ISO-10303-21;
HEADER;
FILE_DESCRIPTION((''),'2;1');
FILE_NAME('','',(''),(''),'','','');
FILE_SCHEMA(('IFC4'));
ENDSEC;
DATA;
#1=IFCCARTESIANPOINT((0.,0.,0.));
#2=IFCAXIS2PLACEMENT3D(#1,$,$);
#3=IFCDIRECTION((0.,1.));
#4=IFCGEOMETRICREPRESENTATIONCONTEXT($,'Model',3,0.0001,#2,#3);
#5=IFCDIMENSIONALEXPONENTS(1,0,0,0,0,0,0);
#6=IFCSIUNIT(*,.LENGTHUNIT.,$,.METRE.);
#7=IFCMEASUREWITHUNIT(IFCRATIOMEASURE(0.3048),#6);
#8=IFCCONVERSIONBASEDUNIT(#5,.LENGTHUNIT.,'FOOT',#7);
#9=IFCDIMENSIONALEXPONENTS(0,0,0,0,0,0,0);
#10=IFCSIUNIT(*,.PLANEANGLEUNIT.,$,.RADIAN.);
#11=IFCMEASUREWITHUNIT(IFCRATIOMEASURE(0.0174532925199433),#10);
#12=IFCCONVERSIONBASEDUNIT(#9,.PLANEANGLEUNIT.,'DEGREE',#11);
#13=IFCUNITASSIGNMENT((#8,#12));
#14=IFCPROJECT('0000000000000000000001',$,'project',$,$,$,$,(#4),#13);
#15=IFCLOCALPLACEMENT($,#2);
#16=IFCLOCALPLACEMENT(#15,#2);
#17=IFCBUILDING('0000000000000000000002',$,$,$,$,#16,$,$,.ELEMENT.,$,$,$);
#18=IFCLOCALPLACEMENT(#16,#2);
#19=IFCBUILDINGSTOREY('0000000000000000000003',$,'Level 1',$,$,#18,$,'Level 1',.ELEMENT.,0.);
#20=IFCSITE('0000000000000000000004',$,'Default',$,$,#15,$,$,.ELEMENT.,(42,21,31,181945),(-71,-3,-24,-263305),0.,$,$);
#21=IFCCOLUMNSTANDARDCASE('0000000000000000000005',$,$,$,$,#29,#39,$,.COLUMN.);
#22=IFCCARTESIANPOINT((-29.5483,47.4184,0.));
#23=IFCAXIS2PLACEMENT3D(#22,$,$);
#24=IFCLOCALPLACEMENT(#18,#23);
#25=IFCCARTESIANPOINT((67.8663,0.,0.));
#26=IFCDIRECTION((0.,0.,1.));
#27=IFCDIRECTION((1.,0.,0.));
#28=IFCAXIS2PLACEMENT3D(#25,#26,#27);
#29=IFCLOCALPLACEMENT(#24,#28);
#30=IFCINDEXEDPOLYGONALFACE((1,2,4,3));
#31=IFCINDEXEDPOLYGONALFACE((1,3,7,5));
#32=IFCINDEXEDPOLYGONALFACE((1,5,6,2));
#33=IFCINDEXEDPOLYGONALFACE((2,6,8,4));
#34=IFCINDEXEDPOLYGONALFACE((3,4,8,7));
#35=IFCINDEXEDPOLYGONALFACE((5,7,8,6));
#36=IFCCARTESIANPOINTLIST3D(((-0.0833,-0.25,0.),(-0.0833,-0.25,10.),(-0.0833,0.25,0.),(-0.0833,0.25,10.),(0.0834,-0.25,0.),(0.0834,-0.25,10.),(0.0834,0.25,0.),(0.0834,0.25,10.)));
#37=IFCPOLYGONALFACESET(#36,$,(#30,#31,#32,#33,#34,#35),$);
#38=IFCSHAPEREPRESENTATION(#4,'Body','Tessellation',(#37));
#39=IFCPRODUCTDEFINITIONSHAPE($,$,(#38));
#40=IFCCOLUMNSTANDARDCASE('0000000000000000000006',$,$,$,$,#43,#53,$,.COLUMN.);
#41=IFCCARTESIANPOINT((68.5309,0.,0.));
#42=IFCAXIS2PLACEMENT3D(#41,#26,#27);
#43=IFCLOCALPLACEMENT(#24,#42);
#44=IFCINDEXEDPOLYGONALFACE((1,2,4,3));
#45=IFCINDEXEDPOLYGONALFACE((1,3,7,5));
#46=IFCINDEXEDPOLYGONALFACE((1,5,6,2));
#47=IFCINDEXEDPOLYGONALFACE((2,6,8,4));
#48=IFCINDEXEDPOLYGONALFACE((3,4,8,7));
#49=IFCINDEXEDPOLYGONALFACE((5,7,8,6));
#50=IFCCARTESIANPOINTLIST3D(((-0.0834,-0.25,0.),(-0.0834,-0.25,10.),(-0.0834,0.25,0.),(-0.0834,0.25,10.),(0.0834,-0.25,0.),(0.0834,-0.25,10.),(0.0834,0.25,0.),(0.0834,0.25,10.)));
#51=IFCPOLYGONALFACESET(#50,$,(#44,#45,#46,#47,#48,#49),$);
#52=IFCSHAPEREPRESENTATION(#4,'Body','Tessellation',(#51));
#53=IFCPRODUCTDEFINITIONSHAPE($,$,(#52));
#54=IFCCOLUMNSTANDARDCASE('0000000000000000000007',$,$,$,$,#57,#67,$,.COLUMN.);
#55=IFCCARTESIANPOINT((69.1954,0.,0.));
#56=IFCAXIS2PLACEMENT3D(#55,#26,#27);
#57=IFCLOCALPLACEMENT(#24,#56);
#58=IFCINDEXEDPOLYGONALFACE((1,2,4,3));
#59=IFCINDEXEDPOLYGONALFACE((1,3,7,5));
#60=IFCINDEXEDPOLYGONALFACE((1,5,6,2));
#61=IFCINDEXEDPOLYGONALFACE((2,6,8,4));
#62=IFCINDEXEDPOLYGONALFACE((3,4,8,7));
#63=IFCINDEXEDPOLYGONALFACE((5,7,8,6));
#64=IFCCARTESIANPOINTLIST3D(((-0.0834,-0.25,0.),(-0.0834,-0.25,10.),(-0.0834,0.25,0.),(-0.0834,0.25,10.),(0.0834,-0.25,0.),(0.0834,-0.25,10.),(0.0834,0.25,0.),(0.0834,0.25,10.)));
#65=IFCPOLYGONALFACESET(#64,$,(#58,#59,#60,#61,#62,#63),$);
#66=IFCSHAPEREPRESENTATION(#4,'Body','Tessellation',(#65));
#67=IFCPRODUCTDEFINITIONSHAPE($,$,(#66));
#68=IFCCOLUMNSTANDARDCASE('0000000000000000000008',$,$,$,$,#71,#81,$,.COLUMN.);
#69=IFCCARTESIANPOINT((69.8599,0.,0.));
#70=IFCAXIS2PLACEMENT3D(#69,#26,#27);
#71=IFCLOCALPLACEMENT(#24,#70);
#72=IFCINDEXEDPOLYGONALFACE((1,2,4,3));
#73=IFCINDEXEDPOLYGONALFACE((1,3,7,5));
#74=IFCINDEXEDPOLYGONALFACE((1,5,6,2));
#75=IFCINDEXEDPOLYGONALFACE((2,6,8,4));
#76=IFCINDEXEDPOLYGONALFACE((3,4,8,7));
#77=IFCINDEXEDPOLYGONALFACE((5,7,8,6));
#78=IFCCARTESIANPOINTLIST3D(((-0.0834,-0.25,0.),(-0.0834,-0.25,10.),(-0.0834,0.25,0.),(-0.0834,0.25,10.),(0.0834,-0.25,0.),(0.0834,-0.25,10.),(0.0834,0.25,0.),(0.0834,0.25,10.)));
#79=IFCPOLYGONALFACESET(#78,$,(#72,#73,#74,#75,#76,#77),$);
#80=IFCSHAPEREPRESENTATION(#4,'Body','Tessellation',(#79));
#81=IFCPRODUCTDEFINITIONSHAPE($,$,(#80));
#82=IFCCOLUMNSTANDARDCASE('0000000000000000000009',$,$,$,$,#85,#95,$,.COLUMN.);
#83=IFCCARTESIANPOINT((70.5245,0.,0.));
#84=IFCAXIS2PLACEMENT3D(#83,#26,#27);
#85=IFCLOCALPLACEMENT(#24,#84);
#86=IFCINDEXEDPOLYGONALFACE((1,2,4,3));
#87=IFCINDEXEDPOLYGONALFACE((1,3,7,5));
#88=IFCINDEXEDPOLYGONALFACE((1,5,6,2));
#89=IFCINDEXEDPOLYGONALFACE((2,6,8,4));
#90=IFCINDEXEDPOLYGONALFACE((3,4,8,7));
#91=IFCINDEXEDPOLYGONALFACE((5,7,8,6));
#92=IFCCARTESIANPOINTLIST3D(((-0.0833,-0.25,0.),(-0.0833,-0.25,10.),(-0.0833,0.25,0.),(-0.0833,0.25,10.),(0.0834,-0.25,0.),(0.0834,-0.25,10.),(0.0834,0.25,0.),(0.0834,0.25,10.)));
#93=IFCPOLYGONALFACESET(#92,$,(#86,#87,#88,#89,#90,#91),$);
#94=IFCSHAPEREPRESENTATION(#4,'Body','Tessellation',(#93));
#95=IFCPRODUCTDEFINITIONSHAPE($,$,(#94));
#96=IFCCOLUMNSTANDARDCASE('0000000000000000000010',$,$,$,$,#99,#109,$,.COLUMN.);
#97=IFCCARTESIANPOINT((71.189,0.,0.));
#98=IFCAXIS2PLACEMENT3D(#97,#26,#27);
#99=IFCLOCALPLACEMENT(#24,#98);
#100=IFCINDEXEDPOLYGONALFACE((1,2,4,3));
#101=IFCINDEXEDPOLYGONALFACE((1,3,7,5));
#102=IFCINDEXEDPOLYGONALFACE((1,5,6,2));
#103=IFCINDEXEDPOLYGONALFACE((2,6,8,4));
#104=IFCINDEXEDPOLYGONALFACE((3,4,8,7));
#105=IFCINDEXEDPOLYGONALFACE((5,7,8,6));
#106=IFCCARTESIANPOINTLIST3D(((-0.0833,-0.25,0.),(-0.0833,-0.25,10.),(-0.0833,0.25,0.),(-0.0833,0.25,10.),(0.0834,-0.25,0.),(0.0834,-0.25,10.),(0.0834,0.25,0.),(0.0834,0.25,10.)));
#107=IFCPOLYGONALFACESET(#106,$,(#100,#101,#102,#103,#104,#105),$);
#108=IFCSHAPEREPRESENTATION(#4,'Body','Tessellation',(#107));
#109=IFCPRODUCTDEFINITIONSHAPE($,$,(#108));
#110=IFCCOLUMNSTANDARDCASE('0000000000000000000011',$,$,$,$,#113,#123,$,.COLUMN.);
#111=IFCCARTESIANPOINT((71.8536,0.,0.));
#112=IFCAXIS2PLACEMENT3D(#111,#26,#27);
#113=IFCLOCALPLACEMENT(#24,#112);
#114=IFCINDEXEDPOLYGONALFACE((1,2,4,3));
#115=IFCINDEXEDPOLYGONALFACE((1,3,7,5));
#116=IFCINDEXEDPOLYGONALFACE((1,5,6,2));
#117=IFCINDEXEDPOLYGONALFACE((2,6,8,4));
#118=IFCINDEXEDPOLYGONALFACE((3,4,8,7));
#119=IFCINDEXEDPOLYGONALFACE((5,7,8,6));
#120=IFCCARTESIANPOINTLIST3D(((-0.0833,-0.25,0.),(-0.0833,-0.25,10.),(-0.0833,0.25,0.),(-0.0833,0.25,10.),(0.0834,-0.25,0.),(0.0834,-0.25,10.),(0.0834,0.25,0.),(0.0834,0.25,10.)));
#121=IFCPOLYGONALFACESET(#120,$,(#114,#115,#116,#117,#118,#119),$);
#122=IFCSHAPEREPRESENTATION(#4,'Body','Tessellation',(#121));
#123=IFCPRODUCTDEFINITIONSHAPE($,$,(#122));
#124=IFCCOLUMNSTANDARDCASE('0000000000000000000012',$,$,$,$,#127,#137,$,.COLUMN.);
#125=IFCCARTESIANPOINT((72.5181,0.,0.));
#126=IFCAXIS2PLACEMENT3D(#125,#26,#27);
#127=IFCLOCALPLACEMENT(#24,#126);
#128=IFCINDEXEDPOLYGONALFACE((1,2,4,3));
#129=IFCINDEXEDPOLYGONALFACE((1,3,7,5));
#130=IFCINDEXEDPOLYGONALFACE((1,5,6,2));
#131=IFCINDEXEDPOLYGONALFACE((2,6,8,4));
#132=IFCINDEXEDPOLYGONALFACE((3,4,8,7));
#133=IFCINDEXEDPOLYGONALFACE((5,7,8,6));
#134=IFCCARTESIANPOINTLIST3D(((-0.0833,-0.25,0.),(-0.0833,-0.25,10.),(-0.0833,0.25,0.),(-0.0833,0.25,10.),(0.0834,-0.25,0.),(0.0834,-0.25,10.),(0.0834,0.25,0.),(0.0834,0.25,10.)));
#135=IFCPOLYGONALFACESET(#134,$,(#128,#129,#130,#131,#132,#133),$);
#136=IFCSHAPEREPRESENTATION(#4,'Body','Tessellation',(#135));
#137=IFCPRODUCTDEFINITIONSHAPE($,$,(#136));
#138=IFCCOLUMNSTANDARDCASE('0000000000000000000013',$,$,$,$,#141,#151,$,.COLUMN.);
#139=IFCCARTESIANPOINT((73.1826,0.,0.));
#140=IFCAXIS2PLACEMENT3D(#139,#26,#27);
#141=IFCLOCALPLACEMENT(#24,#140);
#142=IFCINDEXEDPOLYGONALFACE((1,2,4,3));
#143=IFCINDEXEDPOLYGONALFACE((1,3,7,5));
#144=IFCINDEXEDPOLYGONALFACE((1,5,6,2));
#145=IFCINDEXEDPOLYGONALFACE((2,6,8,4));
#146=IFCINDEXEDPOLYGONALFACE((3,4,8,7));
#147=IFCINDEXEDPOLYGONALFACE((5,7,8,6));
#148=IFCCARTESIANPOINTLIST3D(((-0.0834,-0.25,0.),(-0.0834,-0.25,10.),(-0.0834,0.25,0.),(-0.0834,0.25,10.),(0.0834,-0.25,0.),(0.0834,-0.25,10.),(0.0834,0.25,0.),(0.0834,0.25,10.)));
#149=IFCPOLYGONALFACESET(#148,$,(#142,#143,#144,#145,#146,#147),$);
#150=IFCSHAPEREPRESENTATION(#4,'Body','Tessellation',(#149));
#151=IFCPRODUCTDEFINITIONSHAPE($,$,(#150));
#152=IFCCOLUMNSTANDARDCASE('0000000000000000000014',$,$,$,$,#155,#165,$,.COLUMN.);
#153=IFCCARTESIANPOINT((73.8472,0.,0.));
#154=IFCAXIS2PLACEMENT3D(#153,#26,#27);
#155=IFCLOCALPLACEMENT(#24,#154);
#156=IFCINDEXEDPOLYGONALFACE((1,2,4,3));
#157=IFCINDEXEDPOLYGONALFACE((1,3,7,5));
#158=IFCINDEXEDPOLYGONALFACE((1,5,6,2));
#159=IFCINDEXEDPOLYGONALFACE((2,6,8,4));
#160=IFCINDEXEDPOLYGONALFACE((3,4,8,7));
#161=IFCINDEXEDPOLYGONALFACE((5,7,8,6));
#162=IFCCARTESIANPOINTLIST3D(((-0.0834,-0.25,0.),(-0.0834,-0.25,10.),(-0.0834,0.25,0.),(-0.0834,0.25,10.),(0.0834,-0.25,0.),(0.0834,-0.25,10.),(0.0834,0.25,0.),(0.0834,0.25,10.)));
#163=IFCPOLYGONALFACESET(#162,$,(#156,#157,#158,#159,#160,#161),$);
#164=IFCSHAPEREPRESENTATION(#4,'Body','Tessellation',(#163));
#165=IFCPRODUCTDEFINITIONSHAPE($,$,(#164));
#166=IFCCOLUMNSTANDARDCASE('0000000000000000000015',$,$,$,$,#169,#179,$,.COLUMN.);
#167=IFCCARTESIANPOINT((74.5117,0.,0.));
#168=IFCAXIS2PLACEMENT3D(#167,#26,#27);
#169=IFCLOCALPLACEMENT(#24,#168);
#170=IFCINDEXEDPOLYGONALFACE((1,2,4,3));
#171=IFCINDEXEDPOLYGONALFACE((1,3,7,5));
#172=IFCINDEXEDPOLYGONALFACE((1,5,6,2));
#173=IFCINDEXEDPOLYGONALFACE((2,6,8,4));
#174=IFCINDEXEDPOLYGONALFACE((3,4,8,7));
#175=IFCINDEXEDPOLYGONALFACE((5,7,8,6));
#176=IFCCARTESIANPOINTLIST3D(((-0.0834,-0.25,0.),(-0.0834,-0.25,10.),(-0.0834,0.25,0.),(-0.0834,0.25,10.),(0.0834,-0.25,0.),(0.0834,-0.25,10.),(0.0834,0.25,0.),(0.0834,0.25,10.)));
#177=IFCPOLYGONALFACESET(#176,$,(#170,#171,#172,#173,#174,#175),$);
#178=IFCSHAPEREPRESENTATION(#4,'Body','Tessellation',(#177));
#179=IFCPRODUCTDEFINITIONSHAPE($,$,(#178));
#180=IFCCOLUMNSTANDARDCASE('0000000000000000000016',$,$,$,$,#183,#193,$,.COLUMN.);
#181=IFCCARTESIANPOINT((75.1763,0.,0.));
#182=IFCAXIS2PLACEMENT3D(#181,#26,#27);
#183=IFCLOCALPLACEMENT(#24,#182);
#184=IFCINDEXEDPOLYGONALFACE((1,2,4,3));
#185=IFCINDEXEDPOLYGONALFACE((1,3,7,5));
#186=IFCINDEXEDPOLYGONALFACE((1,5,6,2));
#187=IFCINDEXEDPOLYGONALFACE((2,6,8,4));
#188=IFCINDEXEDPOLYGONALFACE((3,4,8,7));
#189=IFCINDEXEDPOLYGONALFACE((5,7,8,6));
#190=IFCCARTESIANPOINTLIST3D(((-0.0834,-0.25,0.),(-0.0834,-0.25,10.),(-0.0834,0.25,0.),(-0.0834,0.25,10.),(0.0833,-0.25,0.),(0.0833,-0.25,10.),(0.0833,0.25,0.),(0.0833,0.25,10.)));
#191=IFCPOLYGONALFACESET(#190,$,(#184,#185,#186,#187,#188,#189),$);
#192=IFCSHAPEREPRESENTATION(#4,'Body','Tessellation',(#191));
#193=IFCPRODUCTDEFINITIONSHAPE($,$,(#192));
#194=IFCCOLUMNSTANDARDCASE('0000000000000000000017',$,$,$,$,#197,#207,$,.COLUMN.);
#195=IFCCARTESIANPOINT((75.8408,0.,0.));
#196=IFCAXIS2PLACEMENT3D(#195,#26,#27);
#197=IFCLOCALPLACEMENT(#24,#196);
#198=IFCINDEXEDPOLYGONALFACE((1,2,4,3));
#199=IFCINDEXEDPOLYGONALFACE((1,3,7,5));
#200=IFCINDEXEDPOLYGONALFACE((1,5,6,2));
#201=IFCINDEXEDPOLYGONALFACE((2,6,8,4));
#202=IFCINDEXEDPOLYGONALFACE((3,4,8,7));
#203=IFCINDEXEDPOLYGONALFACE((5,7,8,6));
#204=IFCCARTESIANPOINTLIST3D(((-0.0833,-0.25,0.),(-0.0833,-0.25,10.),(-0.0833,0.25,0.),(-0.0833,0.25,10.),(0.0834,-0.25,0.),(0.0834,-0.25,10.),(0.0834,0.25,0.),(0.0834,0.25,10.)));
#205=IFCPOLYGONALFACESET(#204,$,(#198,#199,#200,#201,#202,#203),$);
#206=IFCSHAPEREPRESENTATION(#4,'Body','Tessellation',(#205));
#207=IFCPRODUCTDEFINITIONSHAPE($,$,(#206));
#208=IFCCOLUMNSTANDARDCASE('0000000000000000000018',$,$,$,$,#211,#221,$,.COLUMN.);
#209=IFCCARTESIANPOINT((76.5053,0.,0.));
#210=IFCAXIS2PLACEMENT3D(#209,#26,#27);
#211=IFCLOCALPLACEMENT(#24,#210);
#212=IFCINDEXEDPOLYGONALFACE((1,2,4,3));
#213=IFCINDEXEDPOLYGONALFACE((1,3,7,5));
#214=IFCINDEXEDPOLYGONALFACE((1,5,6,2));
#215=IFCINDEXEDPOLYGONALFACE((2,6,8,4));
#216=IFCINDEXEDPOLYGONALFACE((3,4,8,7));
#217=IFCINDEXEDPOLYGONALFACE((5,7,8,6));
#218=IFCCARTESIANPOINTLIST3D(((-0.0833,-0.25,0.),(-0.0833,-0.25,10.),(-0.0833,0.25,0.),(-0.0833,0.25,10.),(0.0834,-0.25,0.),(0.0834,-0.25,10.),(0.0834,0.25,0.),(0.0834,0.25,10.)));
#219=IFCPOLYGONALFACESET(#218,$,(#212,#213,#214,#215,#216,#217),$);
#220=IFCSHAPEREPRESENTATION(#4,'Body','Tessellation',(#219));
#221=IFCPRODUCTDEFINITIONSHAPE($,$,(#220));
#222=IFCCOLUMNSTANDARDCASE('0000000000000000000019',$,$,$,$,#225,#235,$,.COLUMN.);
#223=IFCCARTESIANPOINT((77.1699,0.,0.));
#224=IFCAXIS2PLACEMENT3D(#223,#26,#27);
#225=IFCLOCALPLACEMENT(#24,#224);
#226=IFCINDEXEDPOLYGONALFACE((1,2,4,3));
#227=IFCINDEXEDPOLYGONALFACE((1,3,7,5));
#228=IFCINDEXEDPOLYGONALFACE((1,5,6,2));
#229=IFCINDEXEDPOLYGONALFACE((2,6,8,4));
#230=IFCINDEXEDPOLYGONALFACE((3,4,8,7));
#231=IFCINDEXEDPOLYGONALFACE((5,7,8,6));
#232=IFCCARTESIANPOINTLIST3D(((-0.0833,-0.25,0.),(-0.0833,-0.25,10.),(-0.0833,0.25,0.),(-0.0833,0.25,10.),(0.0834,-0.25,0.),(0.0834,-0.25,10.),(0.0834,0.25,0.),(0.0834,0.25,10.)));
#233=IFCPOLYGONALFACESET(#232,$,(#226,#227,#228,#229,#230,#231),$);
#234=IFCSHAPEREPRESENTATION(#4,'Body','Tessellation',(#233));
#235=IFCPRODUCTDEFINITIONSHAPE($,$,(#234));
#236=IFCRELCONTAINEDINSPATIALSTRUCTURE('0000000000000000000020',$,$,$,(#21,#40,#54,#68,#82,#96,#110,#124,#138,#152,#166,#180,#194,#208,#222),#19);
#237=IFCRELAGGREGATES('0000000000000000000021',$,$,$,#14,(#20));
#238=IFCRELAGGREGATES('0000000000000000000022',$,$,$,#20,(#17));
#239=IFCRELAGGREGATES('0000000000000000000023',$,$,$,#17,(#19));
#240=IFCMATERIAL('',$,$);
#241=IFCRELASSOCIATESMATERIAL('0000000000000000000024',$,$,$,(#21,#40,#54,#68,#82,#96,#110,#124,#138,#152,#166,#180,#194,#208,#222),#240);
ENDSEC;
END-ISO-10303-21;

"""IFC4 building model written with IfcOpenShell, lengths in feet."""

from ifc_helpers import new_model, entity, si_unit, converted_unit, direction, frame, origin, place, context, project, spatial, rectangle, extrude, material, element, save


model = new_model("IFC4")

# Units and contexts
model_context = context("Model", 3, precision=0.0001, world=origin(), true_north=direction((0.0, 1.0)))
ifc_project = project(units=[converted_unit("LENGTHUNIT", "FOOT", entity("IfcRatioMeasure", 0.3048), si_unit("LENGTHUNIT", "METRE"), dimensions=[1, 0, 0, 0, 0, 0, 0]), converted_unit("PLANEANGLEUNIT", "DEGREE", entity("IfcRatioMeasure", 0.0174532925199433), si_unit("PLANEANGLEUNIT", "RADIAN"), dimensions=[0, 0, 0, 0, 0, 0, 0])], contexts=[model_context])

# Site, building, storey
site_placement = place(None, origin())
site = spatial("IfcSite", under=ifc_project, at=site_placement, Name="Default", CompositionType="ELEMENT", RefLatitude=(42, 21, 31, 181945), RefLongitude=(-71, -3, -24, -263305), RefElevation=0.0)
building_placement = place(site_placement, origin())
building = spatial("IfcBuilding", under=site, at=building_placement, CompositionType="ELEMENT")
storey_placement = place(building_placement, origin())
storey = spatial("IfcBuildingStorey", under=building, at=storey_placement, Name="Level 1", LongName="Level 1", CompositionType="ELEMENT", Elevation=0.0)

# Columns
ifc_material = material(Name="")
placement = place(storey_placement, frame((-29.5483, 47.4184, 0.0)))
for number, where, z_axis, x_axis in (
    (1, (67.8663, 0.0, 0.0), (0.0, 0.0, 1.0), (1.0, 0.0, 0.0)),
    (2, (68.5309, 0.0, 0.0), (0.0, 0.0, 1.0), (1.0, 0.0, 0.0)),
    (3, (69.1954, 0.0, 0.0), (0.0, 0.0, 1.0), (1.0, 0.0, 0.0)),
    (4, (69.8599, 0.0, 0.0), (0.0, 0.0, 1.0), (1.0, 0.0, 0.0)),
    (5, (70.5245, 0.0, 0.0), (0.0, 0.0, 1.0), (1.0, 0.0, 0.0)),
    (6, (71.189, 0.0, 0.0), (0.0, 0.0, 1.0), (1.0, 0.0, 0.0)),
    (7, (71.8536, 0.0, 0.0), (0.0, 0.0, 1.0), (1.0, 0.0, 0.0)),
    (8, (72.5181, 0.0, 0.0), (0.0, 0.0, 1.0), (1.0, 0.0, 0.0)),
    (9, (73.1826, 0.0, 0.0), (0.0, 0.0, 1.0), (1.0, 0.0, 0.0)),
    (10, (73.8472, 0.0, 0.0), (0.0, 0.0, 1.0), (1.0, 0.0, 0.0)),
    (11, (74.5117, 0.0, 0.0), (0.0, 0.0, 1.0), (1.0, 0.0, 0.0)),
    (12, (75.1763, 0.0, 0.0), (0.0, 0.0, 1.0), (1.0, 0.0, 0.0)),
    (13, (75.8408, 0.0, 0.0), (0.0, 0.0, 1.0), (1.0, 0.0, 0.0)),
    (14, (76.5053, 0.0, 0.0), (0.0, 0.0, 1.0), (1.0, 0.0, 0.0)),
    (15, (77.1699, 0.0, 0.0), (0.0, 0.0, 1.0), (1.0, 0.0, 0.0)),
):
    element("IfcColumnStandardCase", number, at=place(placement, frame(where, z_axis=z_axis, x_axis=x_axis)), inside=storey, material=ifc_material, PredefinedType="COLUMN", context=model_context, shape_type="SweptSolid", body=[
        extrude(rectangle(XDim=0.1667, YDim=0.5), origin(), (0.0, 0.0, 1.0), 10.0),
    ])

save(model, "model.ifc")
